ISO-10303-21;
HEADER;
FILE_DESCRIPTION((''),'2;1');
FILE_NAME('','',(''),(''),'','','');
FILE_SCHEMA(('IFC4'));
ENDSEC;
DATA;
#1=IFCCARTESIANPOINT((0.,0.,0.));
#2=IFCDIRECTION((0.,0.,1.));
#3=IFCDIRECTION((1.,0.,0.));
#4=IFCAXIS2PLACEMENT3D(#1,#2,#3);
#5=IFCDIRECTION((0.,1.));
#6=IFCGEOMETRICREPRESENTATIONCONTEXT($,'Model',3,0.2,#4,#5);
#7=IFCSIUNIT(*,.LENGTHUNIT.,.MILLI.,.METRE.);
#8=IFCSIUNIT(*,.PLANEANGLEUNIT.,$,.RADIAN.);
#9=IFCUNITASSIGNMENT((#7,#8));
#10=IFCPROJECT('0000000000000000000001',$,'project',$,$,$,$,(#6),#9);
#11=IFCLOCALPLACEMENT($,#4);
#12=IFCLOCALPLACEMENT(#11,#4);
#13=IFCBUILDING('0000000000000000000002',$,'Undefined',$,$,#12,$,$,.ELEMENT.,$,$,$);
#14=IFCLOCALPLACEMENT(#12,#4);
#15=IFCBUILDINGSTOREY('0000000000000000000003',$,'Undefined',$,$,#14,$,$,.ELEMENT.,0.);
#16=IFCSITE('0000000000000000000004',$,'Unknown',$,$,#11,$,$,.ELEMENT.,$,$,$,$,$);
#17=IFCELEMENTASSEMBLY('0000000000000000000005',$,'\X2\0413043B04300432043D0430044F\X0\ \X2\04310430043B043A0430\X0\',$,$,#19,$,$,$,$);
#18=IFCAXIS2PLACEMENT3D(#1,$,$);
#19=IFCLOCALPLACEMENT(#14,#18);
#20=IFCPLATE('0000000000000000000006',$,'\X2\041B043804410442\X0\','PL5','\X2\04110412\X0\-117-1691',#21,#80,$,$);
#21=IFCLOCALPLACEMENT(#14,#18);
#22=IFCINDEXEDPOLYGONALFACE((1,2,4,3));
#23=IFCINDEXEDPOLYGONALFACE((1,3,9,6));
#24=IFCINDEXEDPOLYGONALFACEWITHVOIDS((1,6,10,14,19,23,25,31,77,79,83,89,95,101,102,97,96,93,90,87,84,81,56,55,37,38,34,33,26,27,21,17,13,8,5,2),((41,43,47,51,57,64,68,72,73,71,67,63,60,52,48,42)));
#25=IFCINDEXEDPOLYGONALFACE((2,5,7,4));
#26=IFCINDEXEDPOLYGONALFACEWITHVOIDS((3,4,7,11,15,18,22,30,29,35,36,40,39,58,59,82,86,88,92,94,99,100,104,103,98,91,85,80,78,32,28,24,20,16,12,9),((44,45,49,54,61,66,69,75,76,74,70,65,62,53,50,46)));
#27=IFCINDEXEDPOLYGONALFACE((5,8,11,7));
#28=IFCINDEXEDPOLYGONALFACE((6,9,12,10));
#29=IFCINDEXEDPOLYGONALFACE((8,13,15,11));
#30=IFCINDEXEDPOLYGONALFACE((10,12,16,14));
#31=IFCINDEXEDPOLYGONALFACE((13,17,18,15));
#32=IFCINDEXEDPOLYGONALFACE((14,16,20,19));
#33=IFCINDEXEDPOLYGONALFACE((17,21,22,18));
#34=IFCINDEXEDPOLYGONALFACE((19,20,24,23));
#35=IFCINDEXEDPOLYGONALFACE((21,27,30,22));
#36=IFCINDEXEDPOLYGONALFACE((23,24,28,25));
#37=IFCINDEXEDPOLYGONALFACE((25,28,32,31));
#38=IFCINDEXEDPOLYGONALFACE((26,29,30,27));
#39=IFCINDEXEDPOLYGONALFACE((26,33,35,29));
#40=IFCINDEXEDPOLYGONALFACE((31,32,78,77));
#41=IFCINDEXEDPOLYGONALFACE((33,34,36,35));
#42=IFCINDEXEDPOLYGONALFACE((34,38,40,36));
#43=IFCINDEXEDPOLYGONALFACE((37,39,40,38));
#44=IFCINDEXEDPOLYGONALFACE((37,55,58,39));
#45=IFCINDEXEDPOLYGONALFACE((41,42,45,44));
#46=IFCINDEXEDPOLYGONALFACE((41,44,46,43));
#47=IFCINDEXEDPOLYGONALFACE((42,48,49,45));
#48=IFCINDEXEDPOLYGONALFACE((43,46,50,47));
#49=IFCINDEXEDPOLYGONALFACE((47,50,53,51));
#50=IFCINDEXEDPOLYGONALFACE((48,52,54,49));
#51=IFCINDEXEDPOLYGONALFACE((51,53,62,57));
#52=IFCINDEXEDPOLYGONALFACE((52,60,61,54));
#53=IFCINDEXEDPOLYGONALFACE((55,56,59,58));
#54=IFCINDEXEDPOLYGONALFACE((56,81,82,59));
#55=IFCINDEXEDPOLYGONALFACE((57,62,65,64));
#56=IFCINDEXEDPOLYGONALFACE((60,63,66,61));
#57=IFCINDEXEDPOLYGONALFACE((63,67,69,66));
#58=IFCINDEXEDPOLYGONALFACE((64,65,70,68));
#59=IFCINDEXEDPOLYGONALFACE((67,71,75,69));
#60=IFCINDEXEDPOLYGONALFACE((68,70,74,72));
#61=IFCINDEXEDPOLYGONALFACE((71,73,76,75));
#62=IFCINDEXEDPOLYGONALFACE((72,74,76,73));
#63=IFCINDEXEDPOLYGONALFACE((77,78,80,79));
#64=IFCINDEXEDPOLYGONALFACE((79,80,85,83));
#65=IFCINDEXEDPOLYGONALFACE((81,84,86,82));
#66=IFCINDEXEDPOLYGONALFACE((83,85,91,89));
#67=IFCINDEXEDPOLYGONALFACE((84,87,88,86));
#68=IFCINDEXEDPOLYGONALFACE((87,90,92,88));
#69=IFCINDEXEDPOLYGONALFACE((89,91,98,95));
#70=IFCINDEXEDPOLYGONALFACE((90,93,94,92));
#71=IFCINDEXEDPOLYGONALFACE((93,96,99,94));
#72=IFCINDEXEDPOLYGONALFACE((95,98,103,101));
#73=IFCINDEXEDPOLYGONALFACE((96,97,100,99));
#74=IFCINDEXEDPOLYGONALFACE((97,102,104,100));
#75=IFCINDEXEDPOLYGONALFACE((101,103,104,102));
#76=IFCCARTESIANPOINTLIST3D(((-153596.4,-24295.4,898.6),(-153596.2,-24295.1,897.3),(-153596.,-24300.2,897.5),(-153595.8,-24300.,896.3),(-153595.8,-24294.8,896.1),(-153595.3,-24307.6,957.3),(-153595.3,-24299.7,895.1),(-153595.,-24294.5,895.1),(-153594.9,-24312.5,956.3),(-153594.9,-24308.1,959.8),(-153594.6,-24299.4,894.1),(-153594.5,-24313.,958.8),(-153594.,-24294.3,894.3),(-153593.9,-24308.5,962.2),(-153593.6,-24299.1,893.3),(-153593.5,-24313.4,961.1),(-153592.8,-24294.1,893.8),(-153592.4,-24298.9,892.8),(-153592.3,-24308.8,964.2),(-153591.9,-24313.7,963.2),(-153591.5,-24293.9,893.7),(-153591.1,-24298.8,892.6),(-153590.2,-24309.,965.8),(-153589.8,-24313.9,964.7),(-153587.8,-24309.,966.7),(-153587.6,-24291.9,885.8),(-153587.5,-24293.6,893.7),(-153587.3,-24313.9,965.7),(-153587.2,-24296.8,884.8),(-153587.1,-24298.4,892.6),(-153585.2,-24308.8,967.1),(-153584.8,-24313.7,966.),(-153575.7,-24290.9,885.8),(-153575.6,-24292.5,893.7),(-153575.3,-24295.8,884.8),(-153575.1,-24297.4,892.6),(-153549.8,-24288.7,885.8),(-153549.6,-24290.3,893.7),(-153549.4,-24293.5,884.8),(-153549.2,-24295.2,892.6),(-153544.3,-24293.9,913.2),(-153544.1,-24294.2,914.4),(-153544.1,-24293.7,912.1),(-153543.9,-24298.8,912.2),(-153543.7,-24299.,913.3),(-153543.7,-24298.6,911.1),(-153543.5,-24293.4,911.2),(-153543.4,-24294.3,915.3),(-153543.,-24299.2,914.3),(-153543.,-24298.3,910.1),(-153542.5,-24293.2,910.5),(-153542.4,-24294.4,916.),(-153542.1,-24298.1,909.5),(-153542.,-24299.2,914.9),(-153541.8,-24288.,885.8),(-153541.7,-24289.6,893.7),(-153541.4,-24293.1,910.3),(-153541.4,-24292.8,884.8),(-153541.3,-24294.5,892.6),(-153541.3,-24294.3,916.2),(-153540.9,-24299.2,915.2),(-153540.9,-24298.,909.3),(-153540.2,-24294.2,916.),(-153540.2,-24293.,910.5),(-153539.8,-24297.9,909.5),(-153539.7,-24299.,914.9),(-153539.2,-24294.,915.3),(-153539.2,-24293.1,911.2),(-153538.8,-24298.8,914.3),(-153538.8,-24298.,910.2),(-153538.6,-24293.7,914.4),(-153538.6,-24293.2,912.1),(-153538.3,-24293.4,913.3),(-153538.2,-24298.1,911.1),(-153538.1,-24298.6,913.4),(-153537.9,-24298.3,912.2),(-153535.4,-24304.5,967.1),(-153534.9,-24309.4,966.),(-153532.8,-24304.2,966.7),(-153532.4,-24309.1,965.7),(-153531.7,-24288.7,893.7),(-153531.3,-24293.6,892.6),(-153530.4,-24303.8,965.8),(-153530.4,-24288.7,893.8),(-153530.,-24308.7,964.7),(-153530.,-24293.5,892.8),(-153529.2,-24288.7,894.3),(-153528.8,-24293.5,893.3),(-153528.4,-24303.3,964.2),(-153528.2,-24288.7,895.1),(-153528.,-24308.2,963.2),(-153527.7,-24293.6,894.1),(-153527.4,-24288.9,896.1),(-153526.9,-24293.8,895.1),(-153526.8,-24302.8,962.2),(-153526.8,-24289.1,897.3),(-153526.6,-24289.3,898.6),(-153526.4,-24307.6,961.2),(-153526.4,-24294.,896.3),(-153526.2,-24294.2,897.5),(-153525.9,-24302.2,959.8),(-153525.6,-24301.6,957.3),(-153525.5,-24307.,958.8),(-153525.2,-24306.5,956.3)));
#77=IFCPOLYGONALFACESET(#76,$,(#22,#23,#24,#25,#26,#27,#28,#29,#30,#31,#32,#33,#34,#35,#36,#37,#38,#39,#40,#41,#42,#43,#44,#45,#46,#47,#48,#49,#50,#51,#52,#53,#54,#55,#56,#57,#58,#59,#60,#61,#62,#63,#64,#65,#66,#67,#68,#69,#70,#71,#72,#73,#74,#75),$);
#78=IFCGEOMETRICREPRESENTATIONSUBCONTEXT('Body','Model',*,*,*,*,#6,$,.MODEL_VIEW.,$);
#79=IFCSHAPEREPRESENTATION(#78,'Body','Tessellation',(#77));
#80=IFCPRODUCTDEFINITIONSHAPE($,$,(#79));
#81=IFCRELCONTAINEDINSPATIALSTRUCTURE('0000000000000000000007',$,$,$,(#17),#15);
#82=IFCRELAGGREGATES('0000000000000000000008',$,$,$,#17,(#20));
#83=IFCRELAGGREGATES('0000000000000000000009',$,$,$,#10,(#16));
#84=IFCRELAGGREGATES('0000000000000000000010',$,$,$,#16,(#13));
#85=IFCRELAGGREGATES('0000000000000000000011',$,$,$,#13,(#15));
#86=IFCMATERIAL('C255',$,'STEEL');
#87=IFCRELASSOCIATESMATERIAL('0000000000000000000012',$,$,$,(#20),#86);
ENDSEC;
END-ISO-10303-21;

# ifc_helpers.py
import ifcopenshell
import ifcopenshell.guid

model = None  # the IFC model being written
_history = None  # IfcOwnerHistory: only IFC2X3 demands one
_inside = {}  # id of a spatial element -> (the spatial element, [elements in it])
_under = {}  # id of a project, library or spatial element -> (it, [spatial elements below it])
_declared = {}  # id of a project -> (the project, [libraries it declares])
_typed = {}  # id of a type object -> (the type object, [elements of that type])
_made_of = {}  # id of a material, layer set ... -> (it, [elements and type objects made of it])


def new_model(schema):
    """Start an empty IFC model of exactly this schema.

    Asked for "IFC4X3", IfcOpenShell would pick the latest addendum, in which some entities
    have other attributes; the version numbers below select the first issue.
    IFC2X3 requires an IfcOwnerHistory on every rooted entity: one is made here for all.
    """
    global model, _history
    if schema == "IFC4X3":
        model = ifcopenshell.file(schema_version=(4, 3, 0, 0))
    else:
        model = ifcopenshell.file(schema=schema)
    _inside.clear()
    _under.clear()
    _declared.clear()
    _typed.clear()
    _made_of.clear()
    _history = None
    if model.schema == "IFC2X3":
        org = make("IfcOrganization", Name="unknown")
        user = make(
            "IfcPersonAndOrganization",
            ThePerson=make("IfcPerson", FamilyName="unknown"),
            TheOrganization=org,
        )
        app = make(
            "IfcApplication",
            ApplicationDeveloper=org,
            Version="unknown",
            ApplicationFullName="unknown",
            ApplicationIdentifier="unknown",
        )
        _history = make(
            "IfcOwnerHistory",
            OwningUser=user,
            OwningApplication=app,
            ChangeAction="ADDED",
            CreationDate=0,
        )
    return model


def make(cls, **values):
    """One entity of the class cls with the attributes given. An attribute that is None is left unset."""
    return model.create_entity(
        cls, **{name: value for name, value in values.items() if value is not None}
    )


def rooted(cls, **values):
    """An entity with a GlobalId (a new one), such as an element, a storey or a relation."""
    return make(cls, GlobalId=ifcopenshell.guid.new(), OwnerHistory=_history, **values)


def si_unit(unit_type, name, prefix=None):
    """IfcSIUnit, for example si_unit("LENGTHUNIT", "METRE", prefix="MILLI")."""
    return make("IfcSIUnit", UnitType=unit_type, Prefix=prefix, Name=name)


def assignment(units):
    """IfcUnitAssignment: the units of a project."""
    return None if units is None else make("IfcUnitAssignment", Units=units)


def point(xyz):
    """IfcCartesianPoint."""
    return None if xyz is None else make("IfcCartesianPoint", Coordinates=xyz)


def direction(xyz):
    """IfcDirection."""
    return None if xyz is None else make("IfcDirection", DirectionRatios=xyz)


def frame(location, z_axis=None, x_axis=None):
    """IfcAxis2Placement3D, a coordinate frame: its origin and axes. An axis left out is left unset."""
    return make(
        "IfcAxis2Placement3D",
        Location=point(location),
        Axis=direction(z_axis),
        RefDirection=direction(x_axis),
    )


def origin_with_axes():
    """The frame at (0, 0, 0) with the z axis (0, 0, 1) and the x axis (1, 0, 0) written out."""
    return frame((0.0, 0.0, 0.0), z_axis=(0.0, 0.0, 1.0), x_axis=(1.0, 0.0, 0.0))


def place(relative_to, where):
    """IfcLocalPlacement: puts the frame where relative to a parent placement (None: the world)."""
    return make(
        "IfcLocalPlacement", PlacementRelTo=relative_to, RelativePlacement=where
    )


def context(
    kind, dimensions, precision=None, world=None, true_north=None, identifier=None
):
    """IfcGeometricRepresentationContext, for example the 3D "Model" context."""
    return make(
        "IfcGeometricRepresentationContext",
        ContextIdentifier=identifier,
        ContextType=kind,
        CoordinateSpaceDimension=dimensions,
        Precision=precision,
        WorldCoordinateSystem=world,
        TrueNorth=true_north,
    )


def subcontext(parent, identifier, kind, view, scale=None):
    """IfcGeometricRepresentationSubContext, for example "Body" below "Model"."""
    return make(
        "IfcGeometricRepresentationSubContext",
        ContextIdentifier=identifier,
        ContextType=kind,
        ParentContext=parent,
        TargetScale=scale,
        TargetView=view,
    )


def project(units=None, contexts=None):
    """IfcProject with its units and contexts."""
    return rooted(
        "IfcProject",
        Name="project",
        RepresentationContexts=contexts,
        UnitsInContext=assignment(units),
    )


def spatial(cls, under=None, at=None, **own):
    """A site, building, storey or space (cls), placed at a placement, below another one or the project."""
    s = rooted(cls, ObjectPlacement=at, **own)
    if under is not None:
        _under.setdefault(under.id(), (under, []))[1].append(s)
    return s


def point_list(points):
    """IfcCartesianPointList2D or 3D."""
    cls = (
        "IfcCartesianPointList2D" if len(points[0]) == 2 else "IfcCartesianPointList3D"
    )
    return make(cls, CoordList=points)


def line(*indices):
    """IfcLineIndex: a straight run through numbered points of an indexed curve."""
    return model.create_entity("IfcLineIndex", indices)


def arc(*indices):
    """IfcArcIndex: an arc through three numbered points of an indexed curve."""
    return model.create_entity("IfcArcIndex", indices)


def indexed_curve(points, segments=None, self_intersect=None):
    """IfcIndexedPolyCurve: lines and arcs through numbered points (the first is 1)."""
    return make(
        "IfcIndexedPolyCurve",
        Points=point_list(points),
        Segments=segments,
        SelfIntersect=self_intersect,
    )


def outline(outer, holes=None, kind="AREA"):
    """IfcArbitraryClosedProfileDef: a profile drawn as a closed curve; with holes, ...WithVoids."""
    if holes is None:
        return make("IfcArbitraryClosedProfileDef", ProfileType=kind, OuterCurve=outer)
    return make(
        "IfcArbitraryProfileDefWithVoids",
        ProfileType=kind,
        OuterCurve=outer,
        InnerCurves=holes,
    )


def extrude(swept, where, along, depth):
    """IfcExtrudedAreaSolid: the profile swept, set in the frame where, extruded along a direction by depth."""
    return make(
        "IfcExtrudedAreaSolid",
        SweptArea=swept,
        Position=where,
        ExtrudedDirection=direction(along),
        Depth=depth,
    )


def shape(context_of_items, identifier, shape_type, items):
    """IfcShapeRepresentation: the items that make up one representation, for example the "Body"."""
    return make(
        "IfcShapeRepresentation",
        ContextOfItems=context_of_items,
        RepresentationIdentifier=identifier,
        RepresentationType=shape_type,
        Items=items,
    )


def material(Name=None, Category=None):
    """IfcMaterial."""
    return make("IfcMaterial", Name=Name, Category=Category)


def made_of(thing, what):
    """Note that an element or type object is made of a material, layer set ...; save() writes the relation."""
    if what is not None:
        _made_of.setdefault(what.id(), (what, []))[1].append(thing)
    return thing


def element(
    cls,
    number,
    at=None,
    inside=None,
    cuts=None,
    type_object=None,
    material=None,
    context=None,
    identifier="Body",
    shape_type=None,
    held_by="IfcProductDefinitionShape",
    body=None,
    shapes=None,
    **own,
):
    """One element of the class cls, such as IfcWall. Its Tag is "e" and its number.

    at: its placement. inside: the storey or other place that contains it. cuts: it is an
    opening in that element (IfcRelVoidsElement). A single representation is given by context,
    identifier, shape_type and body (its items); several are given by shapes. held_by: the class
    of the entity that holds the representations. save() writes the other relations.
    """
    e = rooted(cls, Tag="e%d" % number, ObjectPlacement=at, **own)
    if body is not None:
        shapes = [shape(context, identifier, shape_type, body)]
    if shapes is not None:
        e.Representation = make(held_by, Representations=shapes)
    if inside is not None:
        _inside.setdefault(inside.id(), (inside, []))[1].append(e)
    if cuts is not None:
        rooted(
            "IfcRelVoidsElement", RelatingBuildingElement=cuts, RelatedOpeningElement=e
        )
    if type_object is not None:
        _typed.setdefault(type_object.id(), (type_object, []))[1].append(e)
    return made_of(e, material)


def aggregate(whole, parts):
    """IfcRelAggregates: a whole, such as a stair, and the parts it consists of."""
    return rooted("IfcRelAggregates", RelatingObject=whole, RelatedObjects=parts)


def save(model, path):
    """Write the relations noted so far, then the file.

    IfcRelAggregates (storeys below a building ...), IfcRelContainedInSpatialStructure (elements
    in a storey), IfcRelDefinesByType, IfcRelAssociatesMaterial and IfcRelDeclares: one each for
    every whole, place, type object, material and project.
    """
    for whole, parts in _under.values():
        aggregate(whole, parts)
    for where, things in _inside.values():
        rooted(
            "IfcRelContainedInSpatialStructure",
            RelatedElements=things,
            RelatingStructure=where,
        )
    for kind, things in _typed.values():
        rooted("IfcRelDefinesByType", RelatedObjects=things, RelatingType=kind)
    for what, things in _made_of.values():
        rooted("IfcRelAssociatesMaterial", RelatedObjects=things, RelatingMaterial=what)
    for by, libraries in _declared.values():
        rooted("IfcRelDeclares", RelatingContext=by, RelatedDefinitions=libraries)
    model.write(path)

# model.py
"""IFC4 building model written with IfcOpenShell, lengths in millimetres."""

from ifc_helpers import new_model, si_unit, direction, frame, origin_with_axes, place, context, subcontext, project, spatial, line, arc, indexed_curve, outline, extrude, material, element, aggregate, save


model = new_model("IFC4")

# Units and contexts
model_context = context("Model", 3, precision=0.2, world=origin_with_axes(), true_north=direction((0.0, 1.0)))
body_context = subcontext(model_context, "Body", "Model", "MODEL_VIEW")
ifc_project = project(units=[si_unit("LENGTHUNIT", "METRE", prefix="MILLI"), si_unit("PLANEANGLEUNIT", "RADIAN")], contexts=[model_context])

# Site, building, storey
site_placement = place(None, origin_with_axes())
site = spatial("IfcSite", under=ifc_project, at=site_placement, Name="Unknown", CompositionType="ELEMENT")
building_placement = place(site_placement, origin_with_axes())
building = spatial("IfcBuilding", under=site, at=building_placement, Name="Undefined", CompositionType="ELEMENT")
storey_placement = place(building_placement, origin_with_axes())
storey = spatial("IfcBuildingStorey", under=building, at=storey_placement, Name="Undefined", CompositionType="ELEMENT", Elevation=0.0)

# Shared definitions
ifc_material_1 = material(Name="C255", Category="STEEL")

# Element assembly, plate, voiding feature
assembly_1_placement = place(storey_placement, frame((-153597.0, -23940.1, 906.5), z_axis=(-0.996285, -0.086114, 0.000024), x_axis=(0.084276, -0.975018, -0.205517)))
assembly_1 = element("IfcElementAssembly", 1, at=assembly_1_placement, inside=storey, Name="Главная балка")
plate_1_placement = place(assembly_1_placement, frame((350.6, 135.0, -40.0), z_axis=(1.0, 0.000054, 0.0), x_axis=(0.0, -0.000054, 1.0)))
plate_1 = element("IfcPlate", 2, at=plate_1_placement, material=ifc_material_1, Name="Лист", Description="PL5", ObjectType="БВ-117-1691", context=body_context, shape_type="SolidModel", body=[
    extrude(outline(indexed_curve([(0.0, 10.0), (2.9, 2.9), (10.0, 0.0), (60.0, 0.0), (67.1, 2.9), (70.0, 10.0), (70.0, 70.0), (68.5, 73.5), (65.0, 75.0), (61.0, 75.0), (61.0, 83.0), (49.0, 83.0), (49.0, 75.0), (23.0, 75.0), (23.0, 83.0), (15.0, 83.0), (15.0, 75.0), (5.0, 75.0), (1.5, 73.5), (0.0, 70.0)], segments=[arc(1, 2, 3), line(3, 4), arc(4, 5, 6), line(6, 7), arc(7, 8, 9), line(9, 10, 11, 12, 13, 14, 15, 16, 17, 18), arc(18, 19, 20), line(20, 1)])), frame((0.0, 0.0, 2.5), z_axis=(0.0, 0.0, 1.0), x_axis=(1.0, 0.0, 0.0)), (0.0, 0.0, -1.0), 5.0),
])
voiding_feature_1_placement = place(plate_1_placement, frame((15.0, 55.0, 10.0), z_axis=(0.007997, -0.999968, -0.000026), x_axis=(0.0, 0.000026, -1.0)))
element("IfcVoidingFeature", 3, at=voiding_feature_1_placement, cuts=plate_1, Name="Балка", ObjectType="(?)", PredefinedType="HOLE", context=body_context, shape_type="SolidModel", body=[
    extrude(outline(indexed_curve([(3.0, 0.0), (2.8, 1.1), (2.1, 2.1), (1.1, 2.8), (0.0, 3.0), (-1.1, 2.8), (-2.1, 2.1), (-2.8, 1.1), (-3.0, 0.0), (-2.8, -1.1), (-2.1, -2.1), (-1.1, -2.8), (0.0, -3.0), (1.1, -2.8), (2.1, -2.1), (2.8, -1.1)], segments=[line(1, 2, 3, 4, 5, 6, 7, 8, 9, 10, 11, 12, 13, 14, 15, 16, 1)])), frame((0.0, 0.0, 0.0), z_axis=(-1.0, 0.0, 0.0), x_axis=(0.0, 0.0, 1.0)), (0.0, 0.0, -1.0), 20.0),
])
aggregate(assembly_1, [plate_1])

save(model, "model.ifc")
